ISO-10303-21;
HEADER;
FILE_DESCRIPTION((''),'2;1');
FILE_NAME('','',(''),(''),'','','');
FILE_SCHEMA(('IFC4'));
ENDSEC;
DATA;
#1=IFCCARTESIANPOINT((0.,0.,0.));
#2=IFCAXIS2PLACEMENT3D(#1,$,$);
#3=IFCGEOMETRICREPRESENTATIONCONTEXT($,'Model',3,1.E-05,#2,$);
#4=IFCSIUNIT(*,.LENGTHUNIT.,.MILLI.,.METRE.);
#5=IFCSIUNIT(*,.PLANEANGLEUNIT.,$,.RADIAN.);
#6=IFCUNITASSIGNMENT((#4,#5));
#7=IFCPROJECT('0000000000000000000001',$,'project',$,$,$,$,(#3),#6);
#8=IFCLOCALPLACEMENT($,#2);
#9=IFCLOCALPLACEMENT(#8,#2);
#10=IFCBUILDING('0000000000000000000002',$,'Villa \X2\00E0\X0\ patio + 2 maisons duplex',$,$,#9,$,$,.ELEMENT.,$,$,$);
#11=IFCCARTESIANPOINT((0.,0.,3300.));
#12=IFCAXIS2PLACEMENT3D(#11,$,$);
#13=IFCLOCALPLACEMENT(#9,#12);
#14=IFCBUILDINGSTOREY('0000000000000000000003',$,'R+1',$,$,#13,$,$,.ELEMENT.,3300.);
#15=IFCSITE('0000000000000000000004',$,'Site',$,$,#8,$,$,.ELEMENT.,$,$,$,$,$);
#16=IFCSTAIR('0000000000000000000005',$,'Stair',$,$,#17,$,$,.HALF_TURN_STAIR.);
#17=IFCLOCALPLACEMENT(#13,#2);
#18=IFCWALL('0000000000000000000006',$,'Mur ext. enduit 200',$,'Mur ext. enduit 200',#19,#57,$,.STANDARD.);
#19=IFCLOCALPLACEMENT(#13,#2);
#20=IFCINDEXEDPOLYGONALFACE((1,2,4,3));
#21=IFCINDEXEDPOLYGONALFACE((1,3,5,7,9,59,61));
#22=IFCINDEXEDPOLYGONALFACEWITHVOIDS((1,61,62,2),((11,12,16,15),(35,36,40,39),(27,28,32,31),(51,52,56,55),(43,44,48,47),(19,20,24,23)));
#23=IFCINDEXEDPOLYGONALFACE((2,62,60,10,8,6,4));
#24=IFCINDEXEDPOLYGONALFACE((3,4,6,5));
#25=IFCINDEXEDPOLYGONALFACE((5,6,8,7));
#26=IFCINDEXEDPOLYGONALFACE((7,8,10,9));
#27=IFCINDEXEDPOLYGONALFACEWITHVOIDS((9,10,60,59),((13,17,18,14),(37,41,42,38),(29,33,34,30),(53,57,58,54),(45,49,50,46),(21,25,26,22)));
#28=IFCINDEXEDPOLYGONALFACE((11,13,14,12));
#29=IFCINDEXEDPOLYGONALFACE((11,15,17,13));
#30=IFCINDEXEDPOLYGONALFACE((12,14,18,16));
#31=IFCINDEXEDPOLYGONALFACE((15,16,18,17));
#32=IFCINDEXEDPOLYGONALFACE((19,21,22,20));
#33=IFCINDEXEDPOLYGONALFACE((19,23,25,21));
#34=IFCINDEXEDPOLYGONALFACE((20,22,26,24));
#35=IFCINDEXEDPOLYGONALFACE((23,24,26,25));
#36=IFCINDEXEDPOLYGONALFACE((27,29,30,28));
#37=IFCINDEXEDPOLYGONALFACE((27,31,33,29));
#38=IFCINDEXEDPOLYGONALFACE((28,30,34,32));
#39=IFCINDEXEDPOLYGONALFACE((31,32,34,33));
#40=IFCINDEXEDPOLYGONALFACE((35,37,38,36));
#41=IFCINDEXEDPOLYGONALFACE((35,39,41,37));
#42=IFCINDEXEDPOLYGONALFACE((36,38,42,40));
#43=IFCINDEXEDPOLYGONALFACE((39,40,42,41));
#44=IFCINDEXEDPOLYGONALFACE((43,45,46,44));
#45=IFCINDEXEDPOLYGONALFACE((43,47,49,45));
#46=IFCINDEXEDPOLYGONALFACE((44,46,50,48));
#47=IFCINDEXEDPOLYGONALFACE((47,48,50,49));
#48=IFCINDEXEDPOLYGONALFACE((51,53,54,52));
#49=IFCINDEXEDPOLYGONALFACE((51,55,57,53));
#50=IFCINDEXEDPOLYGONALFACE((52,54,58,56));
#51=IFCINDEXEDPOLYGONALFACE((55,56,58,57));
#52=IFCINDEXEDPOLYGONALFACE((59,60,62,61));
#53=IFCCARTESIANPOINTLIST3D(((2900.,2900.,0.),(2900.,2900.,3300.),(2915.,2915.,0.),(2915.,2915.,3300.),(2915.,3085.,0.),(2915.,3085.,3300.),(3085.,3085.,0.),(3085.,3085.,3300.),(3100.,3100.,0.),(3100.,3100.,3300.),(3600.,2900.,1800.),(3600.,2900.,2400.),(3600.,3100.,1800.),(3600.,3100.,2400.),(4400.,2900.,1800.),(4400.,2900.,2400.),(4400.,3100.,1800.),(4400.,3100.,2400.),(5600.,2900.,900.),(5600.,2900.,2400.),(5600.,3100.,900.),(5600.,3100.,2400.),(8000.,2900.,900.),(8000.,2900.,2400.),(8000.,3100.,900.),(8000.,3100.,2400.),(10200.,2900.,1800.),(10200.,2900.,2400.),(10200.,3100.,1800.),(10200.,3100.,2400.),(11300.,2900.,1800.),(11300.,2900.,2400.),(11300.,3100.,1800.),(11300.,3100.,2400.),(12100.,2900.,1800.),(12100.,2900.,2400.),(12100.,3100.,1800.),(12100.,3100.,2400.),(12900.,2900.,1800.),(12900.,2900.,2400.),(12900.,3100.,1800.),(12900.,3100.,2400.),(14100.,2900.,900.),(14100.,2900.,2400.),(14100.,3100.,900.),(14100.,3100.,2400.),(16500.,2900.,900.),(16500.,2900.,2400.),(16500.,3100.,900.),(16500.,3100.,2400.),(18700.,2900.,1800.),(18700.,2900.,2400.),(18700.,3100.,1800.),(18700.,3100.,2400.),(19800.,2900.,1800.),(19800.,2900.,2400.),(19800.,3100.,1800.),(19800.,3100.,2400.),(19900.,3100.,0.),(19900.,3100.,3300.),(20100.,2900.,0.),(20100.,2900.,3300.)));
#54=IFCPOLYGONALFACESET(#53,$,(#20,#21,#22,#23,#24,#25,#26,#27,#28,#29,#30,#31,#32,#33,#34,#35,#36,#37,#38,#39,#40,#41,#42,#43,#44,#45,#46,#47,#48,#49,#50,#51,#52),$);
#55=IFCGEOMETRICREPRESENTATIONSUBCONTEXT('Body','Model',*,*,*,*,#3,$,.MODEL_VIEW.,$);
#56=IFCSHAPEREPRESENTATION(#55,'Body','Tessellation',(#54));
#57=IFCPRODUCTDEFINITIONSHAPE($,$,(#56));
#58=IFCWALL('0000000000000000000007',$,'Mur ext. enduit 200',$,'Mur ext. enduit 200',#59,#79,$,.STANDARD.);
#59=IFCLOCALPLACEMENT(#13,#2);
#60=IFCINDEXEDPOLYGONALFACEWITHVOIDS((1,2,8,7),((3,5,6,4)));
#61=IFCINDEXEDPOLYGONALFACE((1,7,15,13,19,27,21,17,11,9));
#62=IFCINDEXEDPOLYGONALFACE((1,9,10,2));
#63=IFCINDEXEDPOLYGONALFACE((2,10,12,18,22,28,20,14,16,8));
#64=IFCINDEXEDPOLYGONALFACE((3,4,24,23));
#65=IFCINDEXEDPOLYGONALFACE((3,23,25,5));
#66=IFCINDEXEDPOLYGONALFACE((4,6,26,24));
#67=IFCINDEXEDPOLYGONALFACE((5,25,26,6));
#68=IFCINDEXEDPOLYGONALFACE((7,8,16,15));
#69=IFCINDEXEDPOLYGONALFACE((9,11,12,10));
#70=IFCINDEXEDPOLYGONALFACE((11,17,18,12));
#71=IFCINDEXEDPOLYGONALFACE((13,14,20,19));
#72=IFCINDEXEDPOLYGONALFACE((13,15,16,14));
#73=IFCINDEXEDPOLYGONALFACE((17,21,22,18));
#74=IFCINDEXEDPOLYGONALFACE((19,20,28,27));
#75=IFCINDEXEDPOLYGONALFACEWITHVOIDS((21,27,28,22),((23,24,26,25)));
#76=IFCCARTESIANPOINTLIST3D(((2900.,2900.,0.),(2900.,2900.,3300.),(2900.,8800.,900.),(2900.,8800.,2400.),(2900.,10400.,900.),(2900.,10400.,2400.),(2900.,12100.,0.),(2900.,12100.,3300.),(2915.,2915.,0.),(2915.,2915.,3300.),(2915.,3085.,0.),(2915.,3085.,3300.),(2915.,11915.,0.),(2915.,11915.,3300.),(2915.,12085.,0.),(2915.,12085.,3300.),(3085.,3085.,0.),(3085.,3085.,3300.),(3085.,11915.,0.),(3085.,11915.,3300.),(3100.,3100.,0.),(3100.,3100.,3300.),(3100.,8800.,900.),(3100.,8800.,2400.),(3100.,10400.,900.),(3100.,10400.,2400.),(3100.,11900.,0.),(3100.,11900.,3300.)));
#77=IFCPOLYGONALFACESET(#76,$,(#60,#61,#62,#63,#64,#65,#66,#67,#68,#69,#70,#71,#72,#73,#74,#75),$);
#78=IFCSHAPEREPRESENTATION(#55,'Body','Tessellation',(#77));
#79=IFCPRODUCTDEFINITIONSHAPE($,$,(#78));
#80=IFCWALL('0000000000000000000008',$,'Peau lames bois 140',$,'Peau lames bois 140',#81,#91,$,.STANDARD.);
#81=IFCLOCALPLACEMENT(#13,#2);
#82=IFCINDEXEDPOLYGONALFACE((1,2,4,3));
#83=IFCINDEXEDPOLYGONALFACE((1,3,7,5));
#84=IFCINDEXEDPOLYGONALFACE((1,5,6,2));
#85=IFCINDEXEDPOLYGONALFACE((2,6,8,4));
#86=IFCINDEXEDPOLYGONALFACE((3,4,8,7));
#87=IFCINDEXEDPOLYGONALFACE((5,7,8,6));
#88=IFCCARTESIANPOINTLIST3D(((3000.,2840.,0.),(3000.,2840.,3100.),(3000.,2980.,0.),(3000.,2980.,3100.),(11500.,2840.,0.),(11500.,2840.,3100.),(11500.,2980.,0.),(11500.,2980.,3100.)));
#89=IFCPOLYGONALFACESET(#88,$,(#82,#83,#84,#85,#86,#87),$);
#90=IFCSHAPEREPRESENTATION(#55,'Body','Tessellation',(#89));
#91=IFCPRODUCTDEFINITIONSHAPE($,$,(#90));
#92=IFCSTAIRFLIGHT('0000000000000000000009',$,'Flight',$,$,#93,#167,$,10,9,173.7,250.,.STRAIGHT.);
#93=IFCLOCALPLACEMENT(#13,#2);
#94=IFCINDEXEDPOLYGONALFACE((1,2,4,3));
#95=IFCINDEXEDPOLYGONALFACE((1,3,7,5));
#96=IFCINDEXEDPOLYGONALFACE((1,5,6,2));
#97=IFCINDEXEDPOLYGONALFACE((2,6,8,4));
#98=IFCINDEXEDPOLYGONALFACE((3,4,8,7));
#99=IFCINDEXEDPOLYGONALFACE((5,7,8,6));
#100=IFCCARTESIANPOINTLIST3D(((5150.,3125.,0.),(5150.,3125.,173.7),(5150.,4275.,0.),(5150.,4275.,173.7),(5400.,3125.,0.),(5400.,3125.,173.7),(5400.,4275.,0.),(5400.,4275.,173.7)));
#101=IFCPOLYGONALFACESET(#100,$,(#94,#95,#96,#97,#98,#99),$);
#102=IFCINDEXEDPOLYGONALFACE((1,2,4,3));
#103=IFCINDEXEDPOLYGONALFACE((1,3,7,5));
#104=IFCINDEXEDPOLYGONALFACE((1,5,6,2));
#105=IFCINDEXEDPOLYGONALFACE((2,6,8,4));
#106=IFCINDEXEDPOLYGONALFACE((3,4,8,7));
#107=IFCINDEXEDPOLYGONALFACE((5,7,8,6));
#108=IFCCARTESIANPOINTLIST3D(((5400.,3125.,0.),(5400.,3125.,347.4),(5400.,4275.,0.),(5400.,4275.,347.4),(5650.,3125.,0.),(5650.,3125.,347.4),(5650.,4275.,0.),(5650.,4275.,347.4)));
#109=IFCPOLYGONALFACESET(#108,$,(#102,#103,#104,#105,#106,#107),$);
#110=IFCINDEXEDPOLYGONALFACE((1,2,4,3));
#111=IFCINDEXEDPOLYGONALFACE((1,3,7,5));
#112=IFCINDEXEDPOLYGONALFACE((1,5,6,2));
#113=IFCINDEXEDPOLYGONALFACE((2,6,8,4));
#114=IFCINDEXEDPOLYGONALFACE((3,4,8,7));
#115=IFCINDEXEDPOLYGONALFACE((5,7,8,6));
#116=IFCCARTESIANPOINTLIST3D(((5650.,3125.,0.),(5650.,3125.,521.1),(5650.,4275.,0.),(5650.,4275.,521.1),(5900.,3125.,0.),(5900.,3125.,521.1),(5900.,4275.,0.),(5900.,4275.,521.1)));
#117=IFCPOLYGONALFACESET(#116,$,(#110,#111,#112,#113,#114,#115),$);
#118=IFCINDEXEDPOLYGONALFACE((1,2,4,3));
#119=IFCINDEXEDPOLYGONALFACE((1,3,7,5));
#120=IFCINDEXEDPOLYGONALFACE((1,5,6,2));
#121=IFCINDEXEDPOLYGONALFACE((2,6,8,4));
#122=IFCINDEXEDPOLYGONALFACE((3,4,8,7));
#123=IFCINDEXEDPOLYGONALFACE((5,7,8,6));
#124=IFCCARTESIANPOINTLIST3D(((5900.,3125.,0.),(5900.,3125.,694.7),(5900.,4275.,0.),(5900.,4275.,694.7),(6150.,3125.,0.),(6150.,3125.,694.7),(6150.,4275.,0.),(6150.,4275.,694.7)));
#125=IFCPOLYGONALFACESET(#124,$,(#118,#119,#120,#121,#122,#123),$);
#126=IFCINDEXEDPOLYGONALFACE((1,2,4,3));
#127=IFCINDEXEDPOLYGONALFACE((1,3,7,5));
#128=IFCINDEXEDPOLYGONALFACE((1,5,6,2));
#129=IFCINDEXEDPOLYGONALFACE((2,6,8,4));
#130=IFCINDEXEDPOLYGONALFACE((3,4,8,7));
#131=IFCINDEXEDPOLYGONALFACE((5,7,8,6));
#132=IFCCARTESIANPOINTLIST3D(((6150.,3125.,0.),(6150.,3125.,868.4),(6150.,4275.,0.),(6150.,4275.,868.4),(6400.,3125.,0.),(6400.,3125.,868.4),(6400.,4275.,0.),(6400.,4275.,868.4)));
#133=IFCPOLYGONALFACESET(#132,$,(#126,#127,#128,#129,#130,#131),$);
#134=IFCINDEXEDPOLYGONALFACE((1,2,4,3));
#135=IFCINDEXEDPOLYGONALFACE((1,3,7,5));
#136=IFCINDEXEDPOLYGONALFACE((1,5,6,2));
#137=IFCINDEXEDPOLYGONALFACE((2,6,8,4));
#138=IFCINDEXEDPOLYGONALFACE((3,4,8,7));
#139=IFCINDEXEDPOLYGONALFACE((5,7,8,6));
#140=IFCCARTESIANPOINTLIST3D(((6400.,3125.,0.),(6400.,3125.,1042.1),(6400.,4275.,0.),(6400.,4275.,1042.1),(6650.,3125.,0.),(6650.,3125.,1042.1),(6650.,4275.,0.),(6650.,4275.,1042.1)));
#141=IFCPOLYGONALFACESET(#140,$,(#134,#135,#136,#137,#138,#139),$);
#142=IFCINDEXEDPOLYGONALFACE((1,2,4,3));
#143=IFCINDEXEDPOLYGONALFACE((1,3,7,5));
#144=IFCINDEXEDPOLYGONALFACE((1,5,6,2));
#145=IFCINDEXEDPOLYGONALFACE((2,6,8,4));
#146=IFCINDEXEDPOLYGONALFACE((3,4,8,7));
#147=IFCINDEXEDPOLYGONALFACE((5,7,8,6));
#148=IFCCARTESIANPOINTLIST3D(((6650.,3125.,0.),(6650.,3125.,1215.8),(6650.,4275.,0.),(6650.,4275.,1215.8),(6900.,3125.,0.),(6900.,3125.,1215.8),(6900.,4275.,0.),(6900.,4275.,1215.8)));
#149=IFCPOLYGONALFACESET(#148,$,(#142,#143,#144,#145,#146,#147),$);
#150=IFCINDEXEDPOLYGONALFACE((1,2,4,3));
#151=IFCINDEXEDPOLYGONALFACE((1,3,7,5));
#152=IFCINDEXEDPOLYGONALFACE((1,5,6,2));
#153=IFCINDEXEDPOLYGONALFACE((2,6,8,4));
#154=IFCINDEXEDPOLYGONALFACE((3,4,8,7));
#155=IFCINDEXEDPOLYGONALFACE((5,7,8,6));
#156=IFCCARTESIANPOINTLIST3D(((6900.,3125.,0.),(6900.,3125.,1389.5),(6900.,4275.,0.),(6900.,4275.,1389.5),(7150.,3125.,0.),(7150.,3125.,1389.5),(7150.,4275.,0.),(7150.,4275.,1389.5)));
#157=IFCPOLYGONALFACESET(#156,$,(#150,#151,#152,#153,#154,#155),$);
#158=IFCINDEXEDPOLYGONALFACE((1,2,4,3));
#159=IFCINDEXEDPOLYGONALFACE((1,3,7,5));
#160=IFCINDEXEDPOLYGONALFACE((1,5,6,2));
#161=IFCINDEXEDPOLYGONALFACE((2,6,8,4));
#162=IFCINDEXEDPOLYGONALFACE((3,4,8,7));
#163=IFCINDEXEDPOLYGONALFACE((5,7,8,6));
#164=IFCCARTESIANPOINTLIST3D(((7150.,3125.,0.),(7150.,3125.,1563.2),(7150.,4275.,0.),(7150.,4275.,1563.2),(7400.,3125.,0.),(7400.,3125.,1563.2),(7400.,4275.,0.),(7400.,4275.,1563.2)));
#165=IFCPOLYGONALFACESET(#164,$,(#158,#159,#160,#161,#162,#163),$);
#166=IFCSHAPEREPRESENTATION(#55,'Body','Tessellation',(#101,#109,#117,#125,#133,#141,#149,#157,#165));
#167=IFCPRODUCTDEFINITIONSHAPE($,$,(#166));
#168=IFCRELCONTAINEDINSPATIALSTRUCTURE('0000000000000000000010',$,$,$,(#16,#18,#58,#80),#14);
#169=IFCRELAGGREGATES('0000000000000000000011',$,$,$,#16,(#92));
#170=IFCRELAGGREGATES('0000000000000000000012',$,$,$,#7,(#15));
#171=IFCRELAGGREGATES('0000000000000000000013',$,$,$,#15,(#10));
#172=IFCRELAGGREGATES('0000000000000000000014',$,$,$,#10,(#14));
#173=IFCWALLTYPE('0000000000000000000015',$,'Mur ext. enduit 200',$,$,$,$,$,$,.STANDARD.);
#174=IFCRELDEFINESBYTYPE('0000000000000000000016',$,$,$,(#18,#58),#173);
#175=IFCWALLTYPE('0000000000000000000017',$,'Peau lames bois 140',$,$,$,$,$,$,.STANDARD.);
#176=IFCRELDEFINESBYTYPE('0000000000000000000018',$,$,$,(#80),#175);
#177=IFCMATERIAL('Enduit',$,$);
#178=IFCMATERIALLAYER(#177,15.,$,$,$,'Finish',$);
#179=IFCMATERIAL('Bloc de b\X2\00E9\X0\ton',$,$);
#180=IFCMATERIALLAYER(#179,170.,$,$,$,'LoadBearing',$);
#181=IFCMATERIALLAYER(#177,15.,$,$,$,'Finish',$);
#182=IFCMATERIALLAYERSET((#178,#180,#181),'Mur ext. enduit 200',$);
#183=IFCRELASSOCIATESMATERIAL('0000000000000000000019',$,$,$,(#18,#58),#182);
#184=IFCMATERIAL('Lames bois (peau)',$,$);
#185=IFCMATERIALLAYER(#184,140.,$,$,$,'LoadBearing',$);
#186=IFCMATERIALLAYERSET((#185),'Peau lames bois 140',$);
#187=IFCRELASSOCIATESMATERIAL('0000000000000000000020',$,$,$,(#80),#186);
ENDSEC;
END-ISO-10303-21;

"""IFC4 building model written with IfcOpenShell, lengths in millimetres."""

from ifc_helpers import new_model, si_unit, frame, frame_2d, origin, place, context, subcontext, project, spatial, polyline, rectangle, outline, extrude, material, layer, layer_set, layer_usage, type_object, element, aggregate, save


model = new_model("IFC4")

# Units and contexts
model_context = context("Model", 3, precision=1e-05, world=origin())
body_context = subcontext(model_context, "Body", "Model", "MODEL_VIEW")
ifc_project = project(units=[si_unit("LENGTHUNIT", "METRE", prefix="MILLI"), si_unit("PLANEANGLEUNIT", "RADIAN")], contexts=[model_context])

# Site, building, storey
site_placement = place(None, origin())
site = spatial("IfcSite", under=ifc_project, at=site_placement, Name="Site", CompositionType="ELEMENT")
building_placement = place(site_placement, origin())
building = spatial("IfcBuilding", under=site, at=building_placement, Name="Villa à patio + 2 maisons duplex", CompositionType="ELEMENT")
storey_placement = place(building_placement, frame((0.0, 0.0, 3300.0)))
storey = spatial("IfcBuildingStorey", under=building, at=storey_placement, Name="R+1", CompositionType="ELEMENT", Elevation=3300.0)

# Stair
stair_1_placement = place(storey_placement, origin())
stair_1 = element("IfcStair", 1, at=stair_1_placement, inside=storey, Name="Stair", PredefinedType="HALF_TURN_STAIR")

# Shared definitions
ifc_material_1 = material(Name="Enduit")
ifc_material_2 = material(Name="Bloc de béton")

# Wall, openings
ifc_layer_1 = layer(ifc_material_1, 15.0, Category="Finish")
ifc_layer_2 = layer(ifc_material_2, 170.0, Category="LoadBearing")
ifc_layer_3 = layer(ifc_material_1, 15.0, Category="Finish")
ifc_layer_set_1 = layer_set([ifc_layer_1, ifc_layer_2, ifc_layer_3], Name="Mur ext. enduit 200")
ifc_layer_usage_1 = layer_usage(ifc_layer_set_1, "AXIS2", "NEGATIVE", 100.0)
wall_type_1 = type_object("IfcWallType", Name="Mur ext. enduit 200", PredefinedType="STANDARD")
wall_1_placement = place(storey_placement, frame((3000.0, 3000.0, 0.0), z_axis=(0.0, 0.0, 1.0), x_axis=(1.0, 0.0, 0.0)))
wall_1 = element("IfcWall", 2, at=wall_1_placement, inside=storey, type_object=wall_type_1, material=ifc_layer_usage_1, Name="Mur ext. enduit 200", ObjectType="Mur ext. enduit 200", PredefinedType="STANDARD", context=body_context, shape_type="SweptSolid", body=[
    extrude(outline(polyline([(-100.0, -100.0), (-85.0, -85.0), (-85.0, 85.0), (85.0, 85.0), (100.0, 100.0), (16900.0, 100.0), (17000.0, 0.0), (17100.0, -100.0), (-100.0, -100.0)])), origin(), (0.0, 0.0, 1.0), 3300.0),
])
opening_1_placement = place(wall_1_placement, frame((600.0, 0.0, 1800.0), z_axis=(0.0, 0.0, 1.0), x_axis=(1.0, 0.0, 0.0)))
element("IfcOpeningElement", 3, at=opening_1_placement, cuts=wall_1, PredefinedType="OPENING", context=body_context, shape_type="SweptSolid", body=[
    extrude(rectangle(XDim=800.0, YDim=220.0, at=frame_2d((400.0, 0.0))), origin(), (0.0, 0.0, 1.0), 600.0),
])
opening_2_placement = place(wall_1_placement, frame((2600.0, 0.0, 900.0), z_axis=(0.0, 0.0, 1.0), x_axis=(1.0, 0.0, 0.0)))
element("IfcOpeningElement", 4, at=opening_2_placement, cuts=wall_1, PredefinedType="OPENING", context=body_context, shape_type="SweptSolid", body=[
    extrude(rectangle(XDim=2400.0, YDim=220.0, at=frame_2d((1200.0, 0.0))), origin(), (0.0, 0.0, 1.0), 1500.0),
])
opening_3_placement = place(wall_1_placement, frame((7200.0, 0.0, 1800.0), z_axis=(0.0, 0.0, 1.0), x_axis=(1.0, 0.0, 0.0)))
element("IfcOpeningElement", 5, at=opening_3_placement, cuts=wall_1, PredefinedType="OPENING", context=body_context, shape_type="SweptSolid", body=[
    extrude(rectangle(XDim=1100.0, YDim=220.0, at=frame_2d((550.0, 0.0))), origin(), (0.0, 0.0, 1.0), 600.0),
])
opening_4_placement = place(wall_1_placement, frame((9100.0, 0.0, 1800.0), z_axis=(0.0, 0.0, 1.0), x_axis=(1.0, 0.0, 0.0)))
element("IfcOpeningElement", 6, at=opening_4_placement, cuts=wall_1, PredefinedType="OPENING", context=body_context, shape_type="SweptSolid", body=[
    extrude(rectangle(XDim=800.0, YDim=220.0, at=frame_2d((400.0, 0.0))), origin(), (0.0, 0.0, 1.0), 600.0),
])
opening_5_placement = place(wall_1_placement, frame((11100.0, 0.0, 900.0), z_axis=(0.0, 0.0, 1.0), x_axis=(1.0, 0.0, 0.0)))
element("IfcOpeningElement", 7, at=opening_5_placement, cuts=wall_1, PredefinedType="OPENING", context=body_context, shape_type="SweptSolid", body=[
    extrude(rectangle(XDim=2400.0, YDim=220.0, at=frame_2d((1200.0, 0.0))), origin(), (0.0, 0.0, 1.0), 1500.0),
])
opening_6_placement = place(wall_1_placement, frame((15700.0, 0.0, 1800.0), z_axis=(0.0, 0.0, 1.0), x_axis=(1.0, 0.0, 0.0)))
element("IfcOpeningElement", 8, at=opening_6_placement, cuts=wall_1, PredefinedType="OPENING", context=body_context, shape_type="SweptSolid", body=[
    extrude(rectangle(XDim=1100.0, YDim=220.0, at=frame_2d((550.0, 0.0))), origin(), (0.0, 0.0, 1.0), 600.0),
])

# Wall, opening
wall_2_placement = place(storey_placement, frame((3000.0, 12000.0, 0.0), z_axis=(0.0, 0.0, 1.0), x_axis=(0.0, -1.0, 0.0)))
wall_2 = element("IfcWall", 9, at=wall_2_placement, inside=storey, type_object=wall_type_1, material=ifc_layer_usage_1, Name="Mur ext. enduit 200", ObjectType="Mur ext. enduit 200", PredefinedType="STANDARD", context=body_context, shape_type="SweptSolid", body=[
    extrude(outline(polyline([(-100.0, -100.0), (-85.0, -85.0), (85.0, -85.0), (85.0, 85.0), (100.0, 100.0), (8900.0, 100.0), (8915.0, 85.0), (8915.0, -85.0), (9085.0, -85.0), (9100.0, -100.0), (-100.0, -100.0)])), origin(), (0.0, 0.0, 1.0), 3300.0),
])
opening_7_placement = place(wall_2_placement, frame((1600.0, 0.0, 900.0), z_axis=(0.0, 0.0, 1.0), x_axis=(1.0, 0.0, 0.0)))
element("IfcOpeningElement", 10, at=opening_7_placement, cuts=wall_2, PredefinedType="OPENING", context=body_context, shape_type="SweptSolid", body=[
    extrude(rectangle(XDim=1600.0, YDim=220.0, at=frame_2d((800.0, 0.0))), origin(), (0.0, 0.0, 1.0), 1500.0),
])

# Wall
ifc_material_3 = material(Name="Lames bois (peau)")
ifc_layer_4 = layer(ifc_material_3, 140.0, Category="LoadBearing")
ifc_layer_set_2 = layer_set([ifc_layer_4], Name="Peau lames bois 140")
ifc_layer_usage_2 = layer_usage(ifc_layer_set_2, "AXIS2", "NEGATIVE", 70.0)
wall_type_2 = type_object("IfcWallType", Name="Peau lames bois 140", PredefinedType="STANDARD")
wall_3_placement = place(storey_placement, frame((3000.0, 2910.0, 0.0), z_axis=(0.0, 0.0, 1.0), x_axis=(1.0, 0.0, 0.0)))
element("IfcWall", 11, at=wall_3_placement, inside=storey, type_object=wall_type_2, material=ifc_layer_usage_2, Name="Peau lames bois 140", ObjectType="Peau lames bois 140", PredefinedType="STANDARD", context=body_context, shape_type="SweptSolid", body=[
    extrude(outline(polyline([(0.0, -70.0), (0.0, 70.0), (8500.0, 70.0), (8500.0, -70.0), (0.0, -70.0)])), origin(), (0.0, 0.0, 1.0), 3100.0),
])

# Stair flight
stair_flight_placement = place(stair_1_placement, frame((5150.0, 3700.0, 0.0), z_axis=(0.0, 0.0, 1.0), x_axis=(1.0, 0.0, 0.0)))
stair_flight = element("IfcStairFlight", 12, at=stair_flight_placement, Name="Flight", NumberOfRisers=10, NumberOfTreads=9, PredefinedType="STRAIGHT", RiserHeight=173.7, TreadLength=250.0, context=body_context, shape_type="SweptSolid", body=[
    extrude(rectangle(XDim=250.0, YDim=1150.0, at=frame_2d((125.0, 0.0))), origin(), (0.0, 0.0, 1.0), 173.7),
    extrude(rectangle(XDim=250.0, YDim=1150.0, at=frame_2d((375.0, 0.0))), origin(), (0.0, 0.0, 1.0), 347.4),
    extrude(rectangle(XDim=250.0, YDim=1150.0, at=frame_2d((625.0, 0.0))), origin(), (0.0, 0.0, 1.0), 521.1),
    extrude(rectangle(XDim=250.0, YDim=1150.0, at=frame_2d((875.0, 0.0))), origin(), (0.0, 0.0, 1.0), 694.7),
    extrude(rectangle(XDim=250.0, YDim=1150.0, at=frame_2d((1125.0, 0.0))), origin(), (0.0, 0.0, 1.0), 868.4),
    extrude(rectangle(XDim=250.0, YDim=1150.0, at=frame_2d((1375.0, 0.0))), origin(), (0.0, 0.0, 1.0), 1042.1),
    extrude(rectangle(XDim=250.0, YDim=1150.0, at=frame_2d((1625.0, 0.0))), origin(), (0.0, 0.0, 1.0), 1215.8),
    extrude(rectangle(XDim=250.0, YDim=1150.0, at=frame_2d((1875.0, 0.0))), origin(), (0.0, 0.0, 1.0), 1389.5),
    extrude(rectangle(XDim=250.0, YDim=1150.0, at=frame_2d((2125.0, 0.0))), origin(), (0.0, 0.0, 1.0), 1563.2),
])
aggregate(stair_1, [stair_flight])

save(model, "model.ifc")
